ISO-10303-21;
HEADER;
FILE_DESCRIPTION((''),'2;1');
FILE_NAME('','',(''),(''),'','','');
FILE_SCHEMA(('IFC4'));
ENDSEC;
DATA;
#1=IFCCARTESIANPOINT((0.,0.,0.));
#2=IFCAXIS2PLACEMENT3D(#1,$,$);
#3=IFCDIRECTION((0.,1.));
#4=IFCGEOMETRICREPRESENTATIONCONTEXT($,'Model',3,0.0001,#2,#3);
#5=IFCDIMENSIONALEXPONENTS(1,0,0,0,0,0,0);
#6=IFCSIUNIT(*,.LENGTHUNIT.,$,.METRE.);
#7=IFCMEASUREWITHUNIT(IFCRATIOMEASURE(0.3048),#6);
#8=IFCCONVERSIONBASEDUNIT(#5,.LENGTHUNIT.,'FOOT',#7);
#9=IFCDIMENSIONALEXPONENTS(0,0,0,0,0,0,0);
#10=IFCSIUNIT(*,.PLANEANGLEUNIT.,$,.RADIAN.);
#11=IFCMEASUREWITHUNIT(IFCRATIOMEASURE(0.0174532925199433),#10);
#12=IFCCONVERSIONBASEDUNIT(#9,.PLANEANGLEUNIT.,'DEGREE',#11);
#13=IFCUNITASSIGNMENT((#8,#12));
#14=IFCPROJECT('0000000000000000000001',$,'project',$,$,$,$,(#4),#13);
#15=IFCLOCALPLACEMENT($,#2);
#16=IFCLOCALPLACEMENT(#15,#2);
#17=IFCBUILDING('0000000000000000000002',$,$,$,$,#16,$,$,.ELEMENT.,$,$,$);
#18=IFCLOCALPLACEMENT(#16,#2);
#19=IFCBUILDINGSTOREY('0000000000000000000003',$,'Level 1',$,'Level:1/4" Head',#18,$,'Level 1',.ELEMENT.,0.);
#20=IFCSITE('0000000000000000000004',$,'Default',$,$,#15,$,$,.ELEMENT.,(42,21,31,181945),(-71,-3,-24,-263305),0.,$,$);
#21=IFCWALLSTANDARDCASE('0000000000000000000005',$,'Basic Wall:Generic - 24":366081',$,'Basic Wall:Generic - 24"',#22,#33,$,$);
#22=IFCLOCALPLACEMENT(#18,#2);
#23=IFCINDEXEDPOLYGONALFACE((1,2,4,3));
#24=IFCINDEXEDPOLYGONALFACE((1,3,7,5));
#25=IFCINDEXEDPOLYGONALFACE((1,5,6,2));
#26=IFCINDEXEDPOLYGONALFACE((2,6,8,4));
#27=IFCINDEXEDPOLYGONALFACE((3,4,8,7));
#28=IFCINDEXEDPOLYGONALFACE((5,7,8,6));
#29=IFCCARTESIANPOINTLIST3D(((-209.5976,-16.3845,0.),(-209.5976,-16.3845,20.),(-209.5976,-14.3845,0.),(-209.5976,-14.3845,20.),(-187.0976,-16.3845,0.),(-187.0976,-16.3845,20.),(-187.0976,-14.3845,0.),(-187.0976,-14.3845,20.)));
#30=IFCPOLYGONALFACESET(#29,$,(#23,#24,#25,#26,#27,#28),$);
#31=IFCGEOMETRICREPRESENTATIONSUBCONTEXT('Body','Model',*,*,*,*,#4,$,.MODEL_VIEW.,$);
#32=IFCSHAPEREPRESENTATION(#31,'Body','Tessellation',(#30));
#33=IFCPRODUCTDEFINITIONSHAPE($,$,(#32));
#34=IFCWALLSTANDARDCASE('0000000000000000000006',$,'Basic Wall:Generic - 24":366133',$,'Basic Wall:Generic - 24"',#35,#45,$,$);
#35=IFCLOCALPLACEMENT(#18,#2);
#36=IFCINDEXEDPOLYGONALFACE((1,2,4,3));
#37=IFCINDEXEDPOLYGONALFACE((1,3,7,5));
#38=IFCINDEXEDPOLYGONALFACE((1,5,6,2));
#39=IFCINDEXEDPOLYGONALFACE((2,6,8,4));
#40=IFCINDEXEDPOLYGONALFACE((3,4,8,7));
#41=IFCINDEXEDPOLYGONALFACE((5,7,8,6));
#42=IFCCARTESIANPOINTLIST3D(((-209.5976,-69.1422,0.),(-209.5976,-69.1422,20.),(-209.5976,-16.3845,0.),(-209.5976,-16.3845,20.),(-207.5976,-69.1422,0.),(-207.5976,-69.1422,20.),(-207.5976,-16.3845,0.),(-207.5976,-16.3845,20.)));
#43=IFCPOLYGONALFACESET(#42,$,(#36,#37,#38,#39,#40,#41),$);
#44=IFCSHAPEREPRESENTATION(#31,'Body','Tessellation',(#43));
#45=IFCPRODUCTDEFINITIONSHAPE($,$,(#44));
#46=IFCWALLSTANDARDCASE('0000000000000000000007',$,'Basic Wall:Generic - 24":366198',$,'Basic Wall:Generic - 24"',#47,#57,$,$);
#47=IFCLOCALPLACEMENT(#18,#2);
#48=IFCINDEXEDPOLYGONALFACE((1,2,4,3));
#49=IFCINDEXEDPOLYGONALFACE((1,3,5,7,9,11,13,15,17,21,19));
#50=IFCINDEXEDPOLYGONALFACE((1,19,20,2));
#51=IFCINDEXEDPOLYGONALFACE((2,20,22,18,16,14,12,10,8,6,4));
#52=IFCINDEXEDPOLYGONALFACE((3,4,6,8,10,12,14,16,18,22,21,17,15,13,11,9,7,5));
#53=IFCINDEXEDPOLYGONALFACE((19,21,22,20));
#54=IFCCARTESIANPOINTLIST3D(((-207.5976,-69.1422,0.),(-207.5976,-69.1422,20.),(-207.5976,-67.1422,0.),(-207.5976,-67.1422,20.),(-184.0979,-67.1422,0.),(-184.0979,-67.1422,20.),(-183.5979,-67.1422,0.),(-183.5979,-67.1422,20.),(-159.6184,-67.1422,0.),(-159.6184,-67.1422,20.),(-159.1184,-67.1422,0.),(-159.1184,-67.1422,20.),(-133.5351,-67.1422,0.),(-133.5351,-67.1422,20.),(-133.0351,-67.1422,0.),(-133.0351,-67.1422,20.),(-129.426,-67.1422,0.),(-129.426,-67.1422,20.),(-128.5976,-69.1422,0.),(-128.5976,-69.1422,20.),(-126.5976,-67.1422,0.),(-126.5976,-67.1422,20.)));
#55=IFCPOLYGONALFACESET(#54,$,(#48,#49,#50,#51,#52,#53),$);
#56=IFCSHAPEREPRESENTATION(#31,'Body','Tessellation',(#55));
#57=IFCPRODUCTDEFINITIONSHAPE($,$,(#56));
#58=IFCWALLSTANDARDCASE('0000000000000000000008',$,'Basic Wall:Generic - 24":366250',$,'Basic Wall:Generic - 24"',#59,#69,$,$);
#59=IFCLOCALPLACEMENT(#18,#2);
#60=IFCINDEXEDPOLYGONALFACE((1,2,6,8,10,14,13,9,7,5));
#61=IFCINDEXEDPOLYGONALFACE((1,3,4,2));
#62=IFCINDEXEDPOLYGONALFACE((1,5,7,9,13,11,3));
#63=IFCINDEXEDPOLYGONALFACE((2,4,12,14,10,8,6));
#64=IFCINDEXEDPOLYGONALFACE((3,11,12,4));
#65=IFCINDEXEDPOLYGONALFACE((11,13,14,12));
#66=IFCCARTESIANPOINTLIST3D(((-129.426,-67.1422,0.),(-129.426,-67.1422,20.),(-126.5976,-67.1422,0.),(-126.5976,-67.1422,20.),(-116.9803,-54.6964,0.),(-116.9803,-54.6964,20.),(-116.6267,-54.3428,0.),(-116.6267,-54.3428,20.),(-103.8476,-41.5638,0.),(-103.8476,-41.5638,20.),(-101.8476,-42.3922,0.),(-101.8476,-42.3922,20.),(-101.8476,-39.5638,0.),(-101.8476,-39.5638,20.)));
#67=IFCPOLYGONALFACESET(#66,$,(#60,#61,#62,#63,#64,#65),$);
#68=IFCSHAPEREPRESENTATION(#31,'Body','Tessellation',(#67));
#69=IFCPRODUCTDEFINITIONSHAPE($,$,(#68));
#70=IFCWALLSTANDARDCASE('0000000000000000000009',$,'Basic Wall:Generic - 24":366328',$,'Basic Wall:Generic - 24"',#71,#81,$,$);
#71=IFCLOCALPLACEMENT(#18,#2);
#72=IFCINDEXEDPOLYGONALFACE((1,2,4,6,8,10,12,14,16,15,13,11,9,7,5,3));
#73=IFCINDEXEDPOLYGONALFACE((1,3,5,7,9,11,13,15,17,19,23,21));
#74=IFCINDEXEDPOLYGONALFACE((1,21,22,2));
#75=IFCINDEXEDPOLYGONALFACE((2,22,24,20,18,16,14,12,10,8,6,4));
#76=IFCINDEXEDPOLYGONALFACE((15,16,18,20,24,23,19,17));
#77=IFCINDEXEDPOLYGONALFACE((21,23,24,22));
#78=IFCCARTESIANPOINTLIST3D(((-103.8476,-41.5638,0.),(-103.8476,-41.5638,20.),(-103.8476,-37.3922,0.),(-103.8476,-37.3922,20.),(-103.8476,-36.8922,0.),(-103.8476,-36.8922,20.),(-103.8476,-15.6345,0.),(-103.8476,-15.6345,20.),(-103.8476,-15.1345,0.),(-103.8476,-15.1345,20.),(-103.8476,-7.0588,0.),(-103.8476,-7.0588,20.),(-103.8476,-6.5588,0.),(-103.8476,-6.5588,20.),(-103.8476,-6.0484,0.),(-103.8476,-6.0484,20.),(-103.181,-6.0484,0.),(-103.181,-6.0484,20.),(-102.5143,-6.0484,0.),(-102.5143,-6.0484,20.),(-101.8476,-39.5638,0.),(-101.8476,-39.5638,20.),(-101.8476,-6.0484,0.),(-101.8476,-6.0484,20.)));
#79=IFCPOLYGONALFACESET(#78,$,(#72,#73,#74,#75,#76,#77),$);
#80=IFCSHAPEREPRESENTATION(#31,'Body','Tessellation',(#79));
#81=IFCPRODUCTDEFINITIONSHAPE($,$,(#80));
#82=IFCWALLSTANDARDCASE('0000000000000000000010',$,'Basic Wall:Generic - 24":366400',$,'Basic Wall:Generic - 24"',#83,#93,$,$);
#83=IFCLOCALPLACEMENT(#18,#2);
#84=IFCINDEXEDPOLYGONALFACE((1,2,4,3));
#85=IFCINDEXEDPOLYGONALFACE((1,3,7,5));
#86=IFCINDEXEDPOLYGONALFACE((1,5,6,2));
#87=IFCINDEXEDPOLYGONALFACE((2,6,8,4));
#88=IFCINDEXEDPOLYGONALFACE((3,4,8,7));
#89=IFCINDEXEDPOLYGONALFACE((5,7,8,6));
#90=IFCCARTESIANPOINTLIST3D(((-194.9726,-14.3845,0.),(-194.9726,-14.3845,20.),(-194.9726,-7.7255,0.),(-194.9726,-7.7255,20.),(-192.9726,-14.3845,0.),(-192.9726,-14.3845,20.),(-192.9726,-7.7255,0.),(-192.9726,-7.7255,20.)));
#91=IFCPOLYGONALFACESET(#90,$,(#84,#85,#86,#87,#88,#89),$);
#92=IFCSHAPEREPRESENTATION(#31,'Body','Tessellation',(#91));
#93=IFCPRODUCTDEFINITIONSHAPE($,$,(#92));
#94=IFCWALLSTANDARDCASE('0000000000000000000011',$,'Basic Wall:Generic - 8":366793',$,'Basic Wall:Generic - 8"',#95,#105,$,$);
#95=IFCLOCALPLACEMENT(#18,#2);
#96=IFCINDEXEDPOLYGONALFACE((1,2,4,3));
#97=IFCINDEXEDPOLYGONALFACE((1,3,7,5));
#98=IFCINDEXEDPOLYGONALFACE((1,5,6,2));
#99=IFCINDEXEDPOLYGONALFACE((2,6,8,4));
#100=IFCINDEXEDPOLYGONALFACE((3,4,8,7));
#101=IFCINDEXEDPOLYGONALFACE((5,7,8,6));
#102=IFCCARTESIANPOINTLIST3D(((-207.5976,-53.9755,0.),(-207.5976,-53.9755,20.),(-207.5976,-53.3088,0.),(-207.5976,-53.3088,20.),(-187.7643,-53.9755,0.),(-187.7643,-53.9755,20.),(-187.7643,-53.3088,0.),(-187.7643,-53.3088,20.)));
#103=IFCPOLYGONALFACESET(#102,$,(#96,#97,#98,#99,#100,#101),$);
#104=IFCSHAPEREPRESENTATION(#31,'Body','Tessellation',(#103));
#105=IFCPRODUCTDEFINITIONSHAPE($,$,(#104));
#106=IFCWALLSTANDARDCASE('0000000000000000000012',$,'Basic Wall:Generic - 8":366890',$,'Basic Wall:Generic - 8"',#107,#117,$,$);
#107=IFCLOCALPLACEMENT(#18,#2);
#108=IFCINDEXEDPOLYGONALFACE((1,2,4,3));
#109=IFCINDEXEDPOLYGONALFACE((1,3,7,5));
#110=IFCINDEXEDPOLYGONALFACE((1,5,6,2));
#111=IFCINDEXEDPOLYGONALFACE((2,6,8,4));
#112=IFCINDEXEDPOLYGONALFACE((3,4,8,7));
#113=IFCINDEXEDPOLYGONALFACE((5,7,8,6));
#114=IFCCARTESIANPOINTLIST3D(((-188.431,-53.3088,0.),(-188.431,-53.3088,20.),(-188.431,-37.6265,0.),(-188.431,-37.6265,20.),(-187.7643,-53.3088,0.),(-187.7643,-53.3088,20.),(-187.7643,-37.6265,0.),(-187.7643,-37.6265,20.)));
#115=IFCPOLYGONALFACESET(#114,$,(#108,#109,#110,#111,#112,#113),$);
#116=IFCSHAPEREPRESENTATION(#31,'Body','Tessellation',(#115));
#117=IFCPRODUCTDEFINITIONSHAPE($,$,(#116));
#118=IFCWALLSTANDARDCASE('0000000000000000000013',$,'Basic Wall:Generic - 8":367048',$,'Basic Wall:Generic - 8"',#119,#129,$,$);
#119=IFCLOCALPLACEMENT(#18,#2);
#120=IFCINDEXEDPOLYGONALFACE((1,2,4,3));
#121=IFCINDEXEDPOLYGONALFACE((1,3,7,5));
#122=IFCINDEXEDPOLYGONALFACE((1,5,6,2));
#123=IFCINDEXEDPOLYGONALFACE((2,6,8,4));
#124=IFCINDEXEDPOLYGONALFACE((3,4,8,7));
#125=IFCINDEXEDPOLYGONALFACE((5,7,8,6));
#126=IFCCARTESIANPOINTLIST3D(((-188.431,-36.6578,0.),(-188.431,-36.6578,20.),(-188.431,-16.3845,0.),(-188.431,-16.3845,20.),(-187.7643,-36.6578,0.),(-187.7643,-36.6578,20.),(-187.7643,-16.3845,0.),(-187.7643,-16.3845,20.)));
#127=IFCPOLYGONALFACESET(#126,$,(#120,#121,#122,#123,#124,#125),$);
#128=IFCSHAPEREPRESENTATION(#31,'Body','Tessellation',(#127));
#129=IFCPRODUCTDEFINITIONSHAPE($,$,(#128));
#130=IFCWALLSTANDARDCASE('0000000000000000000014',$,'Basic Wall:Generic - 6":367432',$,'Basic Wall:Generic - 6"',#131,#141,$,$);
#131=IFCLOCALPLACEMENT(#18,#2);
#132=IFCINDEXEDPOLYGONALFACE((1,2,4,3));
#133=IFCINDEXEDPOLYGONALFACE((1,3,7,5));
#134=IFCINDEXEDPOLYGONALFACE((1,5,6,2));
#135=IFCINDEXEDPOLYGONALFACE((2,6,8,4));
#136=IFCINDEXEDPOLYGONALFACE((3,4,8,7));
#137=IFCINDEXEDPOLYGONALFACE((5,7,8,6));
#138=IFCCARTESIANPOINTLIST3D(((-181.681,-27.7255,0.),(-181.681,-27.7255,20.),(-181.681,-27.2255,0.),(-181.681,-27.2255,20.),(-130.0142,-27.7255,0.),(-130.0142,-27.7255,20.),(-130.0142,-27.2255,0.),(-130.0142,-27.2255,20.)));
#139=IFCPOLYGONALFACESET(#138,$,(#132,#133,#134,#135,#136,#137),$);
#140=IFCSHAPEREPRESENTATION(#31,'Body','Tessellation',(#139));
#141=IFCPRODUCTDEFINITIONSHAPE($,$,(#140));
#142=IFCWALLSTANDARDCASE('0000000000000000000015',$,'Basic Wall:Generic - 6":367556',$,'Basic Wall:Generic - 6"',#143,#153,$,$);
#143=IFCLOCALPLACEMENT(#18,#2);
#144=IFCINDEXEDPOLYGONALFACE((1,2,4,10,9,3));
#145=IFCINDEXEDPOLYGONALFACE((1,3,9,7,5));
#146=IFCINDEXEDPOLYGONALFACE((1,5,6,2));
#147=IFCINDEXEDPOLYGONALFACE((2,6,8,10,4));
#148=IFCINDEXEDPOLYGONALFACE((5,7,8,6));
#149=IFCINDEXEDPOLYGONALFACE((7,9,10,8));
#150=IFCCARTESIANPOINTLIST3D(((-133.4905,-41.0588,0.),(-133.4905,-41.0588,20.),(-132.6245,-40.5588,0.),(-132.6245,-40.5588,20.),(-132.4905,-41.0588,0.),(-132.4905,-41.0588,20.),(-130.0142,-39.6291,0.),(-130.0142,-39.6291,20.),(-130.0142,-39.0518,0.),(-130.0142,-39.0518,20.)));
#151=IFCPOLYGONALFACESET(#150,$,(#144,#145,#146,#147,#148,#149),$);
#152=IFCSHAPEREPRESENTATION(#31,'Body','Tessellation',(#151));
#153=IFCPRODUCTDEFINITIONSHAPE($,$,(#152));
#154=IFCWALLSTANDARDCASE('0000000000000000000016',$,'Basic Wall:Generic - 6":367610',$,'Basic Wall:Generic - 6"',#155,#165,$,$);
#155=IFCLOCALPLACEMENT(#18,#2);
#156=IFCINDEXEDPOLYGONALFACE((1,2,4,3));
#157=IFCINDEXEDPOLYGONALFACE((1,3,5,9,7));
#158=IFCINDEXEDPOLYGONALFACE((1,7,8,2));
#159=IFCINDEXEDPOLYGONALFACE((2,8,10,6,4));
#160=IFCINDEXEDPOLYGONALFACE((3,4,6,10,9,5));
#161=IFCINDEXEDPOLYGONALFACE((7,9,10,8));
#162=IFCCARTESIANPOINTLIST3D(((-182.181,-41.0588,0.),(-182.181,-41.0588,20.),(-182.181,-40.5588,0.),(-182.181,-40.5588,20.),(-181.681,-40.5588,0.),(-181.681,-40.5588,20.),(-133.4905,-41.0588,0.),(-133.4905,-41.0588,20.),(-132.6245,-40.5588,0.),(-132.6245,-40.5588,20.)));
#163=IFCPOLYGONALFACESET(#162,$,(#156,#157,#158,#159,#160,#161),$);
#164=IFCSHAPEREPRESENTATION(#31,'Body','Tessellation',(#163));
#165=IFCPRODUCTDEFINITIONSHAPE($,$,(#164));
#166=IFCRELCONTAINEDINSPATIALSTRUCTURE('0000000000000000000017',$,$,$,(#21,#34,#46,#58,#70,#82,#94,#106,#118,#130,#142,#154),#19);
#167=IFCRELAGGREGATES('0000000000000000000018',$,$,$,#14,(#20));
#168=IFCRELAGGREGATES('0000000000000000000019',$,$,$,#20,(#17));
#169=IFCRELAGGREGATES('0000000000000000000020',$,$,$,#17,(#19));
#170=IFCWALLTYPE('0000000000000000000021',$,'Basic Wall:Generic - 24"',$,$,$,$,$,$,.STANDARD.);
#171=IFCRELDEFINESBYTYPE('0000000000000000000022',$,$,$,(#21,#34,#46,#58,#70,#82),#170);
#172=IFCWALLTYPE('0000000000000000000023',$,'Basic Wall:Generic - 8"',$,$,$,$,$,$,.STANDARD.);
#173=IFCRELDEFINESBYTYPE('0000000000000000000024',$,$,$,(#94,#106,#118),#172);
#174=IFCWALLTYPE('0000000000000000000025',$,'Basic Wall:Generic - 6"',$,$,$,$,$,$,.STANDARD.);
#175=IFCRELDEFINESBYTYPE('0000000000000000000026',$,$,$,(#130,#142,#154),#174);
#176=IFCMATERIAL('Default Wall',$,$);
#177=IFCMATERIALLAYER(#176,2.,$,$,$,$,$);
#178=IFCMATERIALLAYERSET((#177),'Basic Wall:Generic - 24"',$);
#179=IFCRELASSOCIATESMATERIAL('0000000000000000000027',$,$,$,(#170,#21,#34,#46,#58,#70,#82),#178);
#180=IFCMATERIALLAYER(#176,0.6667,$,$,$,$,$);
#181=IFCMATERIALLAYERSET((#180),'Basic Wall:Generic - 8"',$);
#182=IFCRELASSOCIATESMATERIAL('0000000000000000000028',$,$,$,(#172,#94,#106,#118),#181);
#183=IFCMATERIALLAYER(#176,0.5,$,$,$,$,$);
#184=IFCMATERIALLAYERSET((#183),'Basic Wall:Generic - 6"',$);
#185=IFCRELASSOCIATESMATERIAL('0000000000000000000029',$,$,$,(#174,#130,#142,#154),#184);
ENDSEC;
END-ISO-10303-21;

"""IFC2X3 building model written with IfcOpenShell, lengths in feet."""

from ifc_helpers import new_model, entity, si_unit, converted_unit, direction, frame, frame_2d, origin, place, context, subcontext, project, spatial, polyline, rectangle, outline, extrude, material, layer, layer_set, layer_usage, type_object, element, save


model = new_model("IFC2X3")

# Units and contexts
model_context = context("Model", 3, precision=0.0001, world=origin(), true_north=direction((0.0, 1.0)))
body_context = subcontext(model_context, "Body", "Model", "MODEL_VIEW")
ifc_project = project(units=[converted_unit("LENGTHUNIT", "FOOT", entity("IfcRatioMeasure", 0.3048), si_unit("LENGTHUNIT", "METRE"), dimensions=[1, 0, 0, 0, 0, 0, 0]), converted_unit("PLANEANGLEUNIT", "DEGREE", entity("IfcRatioMeasure", 0.0174532925199433), si_unit("PLANEANGLEUNIT", "RADIAN"), dimensions=[0, 0, 0, 0, 0, 0, 0])], contexts=[model_context])

# Site, building, storey
site_placement = place(None, origin())
site = spatial("IfcSite", under=ifc_project, at=site_placement, Name="Default", CompositionType="ELEMENT", RefLatitude=(42, 21, 31, 181945), RefLongitude=(-71, -3, -24, -263305), RefElevation=0.0)
building_placement = place(site_placement, origin())
building = spatial("IfcBuilding", under=site, at=building_placement, CompositionType="ELEMENT")
storey_placement = place(building_placement, origin())
storey = spatial("IfcBuildingStorey", under=building, at=storey_placement, Name="Level 1", ObjectType="Level:1/4\" Head", LongName="Level 1", CompositionType="ELEMENT", Elevation=0.0)

# Walls
ifc_material_1 = material(Name="Default Wall")
ifc_layer_1 = layer(ifc_material_1, 2.0)
ifc_layer_set_1 = layer_set([ifc_layer_1], Name="Basic Wall:Generic - 24\"")
ifc_layer_usage_1 = layer_usage(ifc_layer_set_1, "AXIS2", "NEGATIVE", 1.0)
wall_type_1 = type_object("IfcWallType", Name="Basic Wall:Generic - 24\"", PredefinedType="STANDARD", material=ifc_layer_set_1)
wall_1_placement = place(storey_placement, frame((-187.0976, -15.3845, 0.0), z_axis=(0.0, 0.0, 1.0), x_axis=(-1.0, 0.0, 0.0)))
element("IfcWallStandardCase", 1, at=wall_1_placement, inside=storey, type_object=wall_type_1, material=ifc_layer_usage_1, Name="Basic Wall:Generic - 24\":366081", ObjectType="Basic Wall:Generic - 24\"", context=body_context, shape_type="SweptSolid", body=[
    extrude(rectangle(XDim=22.5, YDim=2.0, at=frame_2d((11.25, 0.0), x_axis=(-1.0, 0.0))), origin(), (0.0, 0.0, 1.0), 20.0),
])
ifc_layer_usage_2 = layer_usage(ifc_layer_set_1, "AXIS2", "NEGATIVE", 1.0)
wall_2_placement = place(storey_placement, frame((-208.5976, -16.3845, 0.0), z_axis=(0.0, 0.0, 1.0), x_axis=(0.0, -1.0, 0.0)))
element("IfcWallStandardCase", 2, at=wall_2_placement, inside=storey, type_object=wall_type_1, material=ifc_layer_usage_2, Name="Basic Wall:Generic - 24\":366133", ObjectType="Basic Wall:Generic - 24\"", context=body_context, shape_type="SweptSolid", body=[
    extrude(rectangle(XDim=52.7576, YDim=2.0, at=frame_2d((26.3788, 0.0), x_axis=(-1.0, 0.0))), origin(), (0.0, 0.0, 1.0), 20.0),
])
ifc_layer_usage_3 = layer_usage(ifc_layer_set_1, "AXIS2", "NEGATIVE", 1.0)
wall_3_placement = place(storey_placement, frame((-207.5976, -68.1422, 0.0)))
element("IfcWallStandardCase", 3, at=wall_3_placement, inside=storey, type_object=wall_type_1, material=ifc_layer_usage_3, Name="Basic Wall:Generic - 24\":366198", ObjectType="Basic Wall:Generic - 24\"", context=body_context, shape_type="SweptSolid", body=[
    extrude(outline(polyline([(79.0, -1.0), (81.0, 1.0), (78.1716, 1.0), (74.5626, 1.0), (74.0626, 1.0), (48.4792, 1.0), (47.9792, 1.0), (23.9997, 1.0), (23.4997, 1.0), (0.0, 1.0), (0.0, -1.0), (79.0, -1.0)])), origin(), (0.0, 0.0, 1.0), 20.0),
])
ifc_layer_usage_4 = layer_usage(ifc_layer_set_1, "AXIS2", "NEGATIVE", 1.0)
wall_4_placement = place(storey_placement, frame((-128.7189, -67.8493, 0.0), z_axis=(0.0, 0.0, 1.0), x_axis=(0.707107, 0.707107, 0.0)))
element("IfcWallStandardCase", 4, at=wall_4_placement, inside=storey, type_object=wall_type_1, material=ifc_layer_usage_4, Name="Basic Wall:Generic - 24\":366250", ObjectType="Basic Wall:Generic - 24\"", context=body_context, shape_type="SweptSolid", body=[
    extrude(outline(polyline([(37.0017, -1.0), (39.0017, 1.0), (36.1733, 1.0), (18.101, 1.0), (17.601, 1.0), (0.0, 1.0), (2.0, -1.0), (37.0017, -1.0)])), origin(), (0.0, 0.0, 1.0), 20.0),
])
ifc_layer_usage_5 = layer_usage(ifc_layer_set_1, "AXIS2", "NEGATIVE", 1.0)
wall_5_placement = place(storey_placement, frame((-102.8476, -41.5638, 0.0), z_axis=(0.0, 0.0, 1.0), x_axis=(0.0, 1.0, 0.0)))
element("IfcWallStandardCase", 5, at=wall_5_placement, inside=storey, type_object=wall_type_1, material=ifc_layer_usage_5, Name="Basic Wall:Generic - 24\":366328", ObjectType="Basic Wall:Generic - 24\"", context=body_context, shape_type="SweptSolid", body=[
    extrude(outline(polyline([(35.5154, -1.0), (35.5154, -0.3333), (35.5154, 0.3333), (35.5154, 1.0), (35.0049, 1.0), (34.5049, 1.0), (26.4293, 1.0), (25.9293, 1.0), (4.6716, 1.0), (4.1716, 1.0), (0.0, 1.0), (2.0, -1.0), (35.5154, -1.0)])), origin(), (0.0, 0.0, 1.0), 20.0),
])
ifc_layer_usage_6 = layer_usage(ifc_layer_set_1, "AXIS2", "NEGATIVE", 1.0)
wall_6_placement = place(storey_placement, frame((-193.9726, -14.3845, 0.0), z_axis=(0.0, 0.0, 1.0), x_axis=(0.0, 1.0, 0.0)))
element("IfcWallStandardCase", 6, at=wall_6_placement, inside=storey, type_object=wall_type_1, material=ifc_layer_usage_6, Name="Basic Wall:Generic - 24\":366400", ObjectType="Basic Wall:Generic - 24\"", context=body_context, shape_type="SweptSolid", body=[
    extrude(rectangle(XDim=6.659, YDim=2.0, at=frame_2d((3.3295, 0.0), x_axis=(-1.0, 0.0))), origin(), (0.0, 0.0, 1.0), 20.0),
])
ifc_layer_2 = layer(ifc_material_1, 0.6667)
ifc_layer_set_2 = layer_set([ifc_layer_2], Name="Basic Wall:Generic - 8\"")
ifc_layer_usage_7 = layer_usage(ifc_layer_set_2, "AXIS2", "NEGATIVE", 0.3333)
wall_type_2 = type_object("IfcWallType", Name="Basic Wall:Generic - 8\"", PredefinedType="STANDARD", material=ifc_layer_set_2)
wall_7_placement = place(storey_placement, frame((-207.5976, -53.6422, 0.0)))
element("IfcWallStandardCase", 7, at=wall_7_placement, inside=storey, type_object=wall_type_2, material=ifc_layer_usage_7, Name="Basic Wall:Generic - 8\":366793", ObjectType="Basic Wall:Generic - 8\"", context=body_context, shape_type="SweptSolid", body=[
    extrude(rectangle(XDim=19.8333, YDim=0.6667, at=frame_2d((9.9167, 0.0), x_axis=(-1.0, 0.0))), origin(), (0.0, 0.0, 1.0), 20.0),
])
ifc_layer_usage_8 = layer_usage(ifc_layer_set_2, "AXIS2", "NEGATIVE", 0.3333)
wall_8_placement = place(storey_placement, frame((-188.0976, -53.3088, 0.0), z_axis=(0.0, 0.0, 1.0), x_axis=(0.0, 1.0, 0.0)))
element("IfcWallStandardCase", 8, at=wall_8_placement, inside=storey, type_object=wall_type_2, material=ifc_layer_usage_8, Name="Basic Wall:Generic - 8\":366890", ObjectType="Basic Wall:Generic - 8\"", context=body_context, shape_type="SweptSolid", body=[
    extrude(rectangle(XDim=15.6823, YDim=0.6667, at=frame_2d((7.8411, 0.0), x_axis=(-1.0, 0.0))), origin(), (0.0, 0.0, 1.0), 20.0),
])
ifc_layer_usage_9 = layer_usage(ifc_layer_set_2, "AXIS2", "NEGATIVE", 0.3333)
wall_9_placement = place(storey_placement, frame((-188.0976, -16.3845, 0.0), z_axis=(0.0, 0.0, 1.0), x_axis=(0.0, -1.0, 0.0)))
element("IfcWallStandardCase", 9, at=wall_9_placement, inside=storey, type_object=wall_type_2, material=ifc_layer_usage_9, Name="Basic Wall:Generic - 8\":367048", ObjectType="Basic Wall:Generic - 8\"", context=body_context, shape_type="SweptSolid", body=[
    extrude(rectangle(XDim=20.2733, YDim=0.6667, at=frame_2d((10.1366, 0.0), x_axis=(-1.0, 0.0))), origin(), (0.0, 0.0, 1.0), 20.0),
])
ifc_layer_3 = layer(ifc_material_1, 0.5)
ifc_layer_set_3 = layer_set([ifc_layer_3], Name="Basic Wall:Generic - 6\"")
ifc_layer_usage_10 = layer_usage(ifc_layer_set_3, "AXIS2", "NEGATIVE", 0.25)
wall_type_3 = type_object("IfcWallType", Name="Basic Wall:Generic - 6\"", PredefinedType="STANDARD", material=ifc_layer_set_3)
wall_10_placement = place(storey_placement, frame((-181.681, -27.4755, 0.0)))
element("IfcWallStandardCase", 10, at=wall_10_placement, inside=storey, type_object=wall_type_3, material=ifc_layer_usage_10, Name="Basic Wall:Generic - 6\":367432", ObjectType="Basic Wall:Generic - 6\"", context=body_context, shape_type="SweptSolid", body=[
    extrude(rectangle(XDim=51.6667, YDim=0.5, at=frame_2d((25.8334, 0.0), x_axis=(-1.0, 0.0))), origin(), (0.0, 0.0, 1.0), 20.0),
])
ifc_layer_usage_11 = layer_usage(ifc_layer_set_3, "AXIS2", "NEGATIVE", 0.25)
wall_11_placement = place(storey_placement, frame((-129.8892, -39.2683, 0.0), z_axis=(0.0, 0.0, 1.0), x_axis=(-0.866025, -0.5, 0.0)))
element("IfcWallStandardCase", 11, at=wall_11_placement, inside=storey, type_object=wall_type_3, material=ifc_layer_usage_11, Name="Basic Wall:Generic - 6\":367556", ObjectType="Basic Wall:Generic - 6\"", context=body_context, shape_type="SweptSolid", body=[
    extrude(outline(polyline([(4.0141, -0.25), (3.1481, 0.25), (0.2887, 0.25), (0.0, -0.25), (3.0141, -0.25), (4.0141, -0.25)])), origin(), (0.0, 0.0, 1.0), 20.0),
])
ifc_layer_usage_12 = layer_usage(ifc_layer_set_3, "AXIS2", "NEGATIVE", 0.25)
wall_12_placement = place(storey_placement, frame((-132.6245, -40.8088, 0.0), z_axis=(0.0, 0.0, 1.0), x_axis=(-1.0, 0.0, 0.0)))
element("IfcWallStandardCase", 12, at=wall_12_placement, inside=storey, type_object=wall_type_3, material=ifc_layer_usage_12, Name="Basic Wall:Generic - 6\":367610", ObjectType="Basic Wall:Generic - 6\"", context=body_context, shape_type="SweptSolid", body=[
    extrude(outline(polyline([(49.5565, -0.25), (49.5565, 0.25), (0.866, 0.25), (0.0, -0.25), (49.0565, -0.25), (49.5565, -0.25)])), origin(), (0.0, 0.0, 1.0), 20.0),
])

save(model, "model.ifc")
